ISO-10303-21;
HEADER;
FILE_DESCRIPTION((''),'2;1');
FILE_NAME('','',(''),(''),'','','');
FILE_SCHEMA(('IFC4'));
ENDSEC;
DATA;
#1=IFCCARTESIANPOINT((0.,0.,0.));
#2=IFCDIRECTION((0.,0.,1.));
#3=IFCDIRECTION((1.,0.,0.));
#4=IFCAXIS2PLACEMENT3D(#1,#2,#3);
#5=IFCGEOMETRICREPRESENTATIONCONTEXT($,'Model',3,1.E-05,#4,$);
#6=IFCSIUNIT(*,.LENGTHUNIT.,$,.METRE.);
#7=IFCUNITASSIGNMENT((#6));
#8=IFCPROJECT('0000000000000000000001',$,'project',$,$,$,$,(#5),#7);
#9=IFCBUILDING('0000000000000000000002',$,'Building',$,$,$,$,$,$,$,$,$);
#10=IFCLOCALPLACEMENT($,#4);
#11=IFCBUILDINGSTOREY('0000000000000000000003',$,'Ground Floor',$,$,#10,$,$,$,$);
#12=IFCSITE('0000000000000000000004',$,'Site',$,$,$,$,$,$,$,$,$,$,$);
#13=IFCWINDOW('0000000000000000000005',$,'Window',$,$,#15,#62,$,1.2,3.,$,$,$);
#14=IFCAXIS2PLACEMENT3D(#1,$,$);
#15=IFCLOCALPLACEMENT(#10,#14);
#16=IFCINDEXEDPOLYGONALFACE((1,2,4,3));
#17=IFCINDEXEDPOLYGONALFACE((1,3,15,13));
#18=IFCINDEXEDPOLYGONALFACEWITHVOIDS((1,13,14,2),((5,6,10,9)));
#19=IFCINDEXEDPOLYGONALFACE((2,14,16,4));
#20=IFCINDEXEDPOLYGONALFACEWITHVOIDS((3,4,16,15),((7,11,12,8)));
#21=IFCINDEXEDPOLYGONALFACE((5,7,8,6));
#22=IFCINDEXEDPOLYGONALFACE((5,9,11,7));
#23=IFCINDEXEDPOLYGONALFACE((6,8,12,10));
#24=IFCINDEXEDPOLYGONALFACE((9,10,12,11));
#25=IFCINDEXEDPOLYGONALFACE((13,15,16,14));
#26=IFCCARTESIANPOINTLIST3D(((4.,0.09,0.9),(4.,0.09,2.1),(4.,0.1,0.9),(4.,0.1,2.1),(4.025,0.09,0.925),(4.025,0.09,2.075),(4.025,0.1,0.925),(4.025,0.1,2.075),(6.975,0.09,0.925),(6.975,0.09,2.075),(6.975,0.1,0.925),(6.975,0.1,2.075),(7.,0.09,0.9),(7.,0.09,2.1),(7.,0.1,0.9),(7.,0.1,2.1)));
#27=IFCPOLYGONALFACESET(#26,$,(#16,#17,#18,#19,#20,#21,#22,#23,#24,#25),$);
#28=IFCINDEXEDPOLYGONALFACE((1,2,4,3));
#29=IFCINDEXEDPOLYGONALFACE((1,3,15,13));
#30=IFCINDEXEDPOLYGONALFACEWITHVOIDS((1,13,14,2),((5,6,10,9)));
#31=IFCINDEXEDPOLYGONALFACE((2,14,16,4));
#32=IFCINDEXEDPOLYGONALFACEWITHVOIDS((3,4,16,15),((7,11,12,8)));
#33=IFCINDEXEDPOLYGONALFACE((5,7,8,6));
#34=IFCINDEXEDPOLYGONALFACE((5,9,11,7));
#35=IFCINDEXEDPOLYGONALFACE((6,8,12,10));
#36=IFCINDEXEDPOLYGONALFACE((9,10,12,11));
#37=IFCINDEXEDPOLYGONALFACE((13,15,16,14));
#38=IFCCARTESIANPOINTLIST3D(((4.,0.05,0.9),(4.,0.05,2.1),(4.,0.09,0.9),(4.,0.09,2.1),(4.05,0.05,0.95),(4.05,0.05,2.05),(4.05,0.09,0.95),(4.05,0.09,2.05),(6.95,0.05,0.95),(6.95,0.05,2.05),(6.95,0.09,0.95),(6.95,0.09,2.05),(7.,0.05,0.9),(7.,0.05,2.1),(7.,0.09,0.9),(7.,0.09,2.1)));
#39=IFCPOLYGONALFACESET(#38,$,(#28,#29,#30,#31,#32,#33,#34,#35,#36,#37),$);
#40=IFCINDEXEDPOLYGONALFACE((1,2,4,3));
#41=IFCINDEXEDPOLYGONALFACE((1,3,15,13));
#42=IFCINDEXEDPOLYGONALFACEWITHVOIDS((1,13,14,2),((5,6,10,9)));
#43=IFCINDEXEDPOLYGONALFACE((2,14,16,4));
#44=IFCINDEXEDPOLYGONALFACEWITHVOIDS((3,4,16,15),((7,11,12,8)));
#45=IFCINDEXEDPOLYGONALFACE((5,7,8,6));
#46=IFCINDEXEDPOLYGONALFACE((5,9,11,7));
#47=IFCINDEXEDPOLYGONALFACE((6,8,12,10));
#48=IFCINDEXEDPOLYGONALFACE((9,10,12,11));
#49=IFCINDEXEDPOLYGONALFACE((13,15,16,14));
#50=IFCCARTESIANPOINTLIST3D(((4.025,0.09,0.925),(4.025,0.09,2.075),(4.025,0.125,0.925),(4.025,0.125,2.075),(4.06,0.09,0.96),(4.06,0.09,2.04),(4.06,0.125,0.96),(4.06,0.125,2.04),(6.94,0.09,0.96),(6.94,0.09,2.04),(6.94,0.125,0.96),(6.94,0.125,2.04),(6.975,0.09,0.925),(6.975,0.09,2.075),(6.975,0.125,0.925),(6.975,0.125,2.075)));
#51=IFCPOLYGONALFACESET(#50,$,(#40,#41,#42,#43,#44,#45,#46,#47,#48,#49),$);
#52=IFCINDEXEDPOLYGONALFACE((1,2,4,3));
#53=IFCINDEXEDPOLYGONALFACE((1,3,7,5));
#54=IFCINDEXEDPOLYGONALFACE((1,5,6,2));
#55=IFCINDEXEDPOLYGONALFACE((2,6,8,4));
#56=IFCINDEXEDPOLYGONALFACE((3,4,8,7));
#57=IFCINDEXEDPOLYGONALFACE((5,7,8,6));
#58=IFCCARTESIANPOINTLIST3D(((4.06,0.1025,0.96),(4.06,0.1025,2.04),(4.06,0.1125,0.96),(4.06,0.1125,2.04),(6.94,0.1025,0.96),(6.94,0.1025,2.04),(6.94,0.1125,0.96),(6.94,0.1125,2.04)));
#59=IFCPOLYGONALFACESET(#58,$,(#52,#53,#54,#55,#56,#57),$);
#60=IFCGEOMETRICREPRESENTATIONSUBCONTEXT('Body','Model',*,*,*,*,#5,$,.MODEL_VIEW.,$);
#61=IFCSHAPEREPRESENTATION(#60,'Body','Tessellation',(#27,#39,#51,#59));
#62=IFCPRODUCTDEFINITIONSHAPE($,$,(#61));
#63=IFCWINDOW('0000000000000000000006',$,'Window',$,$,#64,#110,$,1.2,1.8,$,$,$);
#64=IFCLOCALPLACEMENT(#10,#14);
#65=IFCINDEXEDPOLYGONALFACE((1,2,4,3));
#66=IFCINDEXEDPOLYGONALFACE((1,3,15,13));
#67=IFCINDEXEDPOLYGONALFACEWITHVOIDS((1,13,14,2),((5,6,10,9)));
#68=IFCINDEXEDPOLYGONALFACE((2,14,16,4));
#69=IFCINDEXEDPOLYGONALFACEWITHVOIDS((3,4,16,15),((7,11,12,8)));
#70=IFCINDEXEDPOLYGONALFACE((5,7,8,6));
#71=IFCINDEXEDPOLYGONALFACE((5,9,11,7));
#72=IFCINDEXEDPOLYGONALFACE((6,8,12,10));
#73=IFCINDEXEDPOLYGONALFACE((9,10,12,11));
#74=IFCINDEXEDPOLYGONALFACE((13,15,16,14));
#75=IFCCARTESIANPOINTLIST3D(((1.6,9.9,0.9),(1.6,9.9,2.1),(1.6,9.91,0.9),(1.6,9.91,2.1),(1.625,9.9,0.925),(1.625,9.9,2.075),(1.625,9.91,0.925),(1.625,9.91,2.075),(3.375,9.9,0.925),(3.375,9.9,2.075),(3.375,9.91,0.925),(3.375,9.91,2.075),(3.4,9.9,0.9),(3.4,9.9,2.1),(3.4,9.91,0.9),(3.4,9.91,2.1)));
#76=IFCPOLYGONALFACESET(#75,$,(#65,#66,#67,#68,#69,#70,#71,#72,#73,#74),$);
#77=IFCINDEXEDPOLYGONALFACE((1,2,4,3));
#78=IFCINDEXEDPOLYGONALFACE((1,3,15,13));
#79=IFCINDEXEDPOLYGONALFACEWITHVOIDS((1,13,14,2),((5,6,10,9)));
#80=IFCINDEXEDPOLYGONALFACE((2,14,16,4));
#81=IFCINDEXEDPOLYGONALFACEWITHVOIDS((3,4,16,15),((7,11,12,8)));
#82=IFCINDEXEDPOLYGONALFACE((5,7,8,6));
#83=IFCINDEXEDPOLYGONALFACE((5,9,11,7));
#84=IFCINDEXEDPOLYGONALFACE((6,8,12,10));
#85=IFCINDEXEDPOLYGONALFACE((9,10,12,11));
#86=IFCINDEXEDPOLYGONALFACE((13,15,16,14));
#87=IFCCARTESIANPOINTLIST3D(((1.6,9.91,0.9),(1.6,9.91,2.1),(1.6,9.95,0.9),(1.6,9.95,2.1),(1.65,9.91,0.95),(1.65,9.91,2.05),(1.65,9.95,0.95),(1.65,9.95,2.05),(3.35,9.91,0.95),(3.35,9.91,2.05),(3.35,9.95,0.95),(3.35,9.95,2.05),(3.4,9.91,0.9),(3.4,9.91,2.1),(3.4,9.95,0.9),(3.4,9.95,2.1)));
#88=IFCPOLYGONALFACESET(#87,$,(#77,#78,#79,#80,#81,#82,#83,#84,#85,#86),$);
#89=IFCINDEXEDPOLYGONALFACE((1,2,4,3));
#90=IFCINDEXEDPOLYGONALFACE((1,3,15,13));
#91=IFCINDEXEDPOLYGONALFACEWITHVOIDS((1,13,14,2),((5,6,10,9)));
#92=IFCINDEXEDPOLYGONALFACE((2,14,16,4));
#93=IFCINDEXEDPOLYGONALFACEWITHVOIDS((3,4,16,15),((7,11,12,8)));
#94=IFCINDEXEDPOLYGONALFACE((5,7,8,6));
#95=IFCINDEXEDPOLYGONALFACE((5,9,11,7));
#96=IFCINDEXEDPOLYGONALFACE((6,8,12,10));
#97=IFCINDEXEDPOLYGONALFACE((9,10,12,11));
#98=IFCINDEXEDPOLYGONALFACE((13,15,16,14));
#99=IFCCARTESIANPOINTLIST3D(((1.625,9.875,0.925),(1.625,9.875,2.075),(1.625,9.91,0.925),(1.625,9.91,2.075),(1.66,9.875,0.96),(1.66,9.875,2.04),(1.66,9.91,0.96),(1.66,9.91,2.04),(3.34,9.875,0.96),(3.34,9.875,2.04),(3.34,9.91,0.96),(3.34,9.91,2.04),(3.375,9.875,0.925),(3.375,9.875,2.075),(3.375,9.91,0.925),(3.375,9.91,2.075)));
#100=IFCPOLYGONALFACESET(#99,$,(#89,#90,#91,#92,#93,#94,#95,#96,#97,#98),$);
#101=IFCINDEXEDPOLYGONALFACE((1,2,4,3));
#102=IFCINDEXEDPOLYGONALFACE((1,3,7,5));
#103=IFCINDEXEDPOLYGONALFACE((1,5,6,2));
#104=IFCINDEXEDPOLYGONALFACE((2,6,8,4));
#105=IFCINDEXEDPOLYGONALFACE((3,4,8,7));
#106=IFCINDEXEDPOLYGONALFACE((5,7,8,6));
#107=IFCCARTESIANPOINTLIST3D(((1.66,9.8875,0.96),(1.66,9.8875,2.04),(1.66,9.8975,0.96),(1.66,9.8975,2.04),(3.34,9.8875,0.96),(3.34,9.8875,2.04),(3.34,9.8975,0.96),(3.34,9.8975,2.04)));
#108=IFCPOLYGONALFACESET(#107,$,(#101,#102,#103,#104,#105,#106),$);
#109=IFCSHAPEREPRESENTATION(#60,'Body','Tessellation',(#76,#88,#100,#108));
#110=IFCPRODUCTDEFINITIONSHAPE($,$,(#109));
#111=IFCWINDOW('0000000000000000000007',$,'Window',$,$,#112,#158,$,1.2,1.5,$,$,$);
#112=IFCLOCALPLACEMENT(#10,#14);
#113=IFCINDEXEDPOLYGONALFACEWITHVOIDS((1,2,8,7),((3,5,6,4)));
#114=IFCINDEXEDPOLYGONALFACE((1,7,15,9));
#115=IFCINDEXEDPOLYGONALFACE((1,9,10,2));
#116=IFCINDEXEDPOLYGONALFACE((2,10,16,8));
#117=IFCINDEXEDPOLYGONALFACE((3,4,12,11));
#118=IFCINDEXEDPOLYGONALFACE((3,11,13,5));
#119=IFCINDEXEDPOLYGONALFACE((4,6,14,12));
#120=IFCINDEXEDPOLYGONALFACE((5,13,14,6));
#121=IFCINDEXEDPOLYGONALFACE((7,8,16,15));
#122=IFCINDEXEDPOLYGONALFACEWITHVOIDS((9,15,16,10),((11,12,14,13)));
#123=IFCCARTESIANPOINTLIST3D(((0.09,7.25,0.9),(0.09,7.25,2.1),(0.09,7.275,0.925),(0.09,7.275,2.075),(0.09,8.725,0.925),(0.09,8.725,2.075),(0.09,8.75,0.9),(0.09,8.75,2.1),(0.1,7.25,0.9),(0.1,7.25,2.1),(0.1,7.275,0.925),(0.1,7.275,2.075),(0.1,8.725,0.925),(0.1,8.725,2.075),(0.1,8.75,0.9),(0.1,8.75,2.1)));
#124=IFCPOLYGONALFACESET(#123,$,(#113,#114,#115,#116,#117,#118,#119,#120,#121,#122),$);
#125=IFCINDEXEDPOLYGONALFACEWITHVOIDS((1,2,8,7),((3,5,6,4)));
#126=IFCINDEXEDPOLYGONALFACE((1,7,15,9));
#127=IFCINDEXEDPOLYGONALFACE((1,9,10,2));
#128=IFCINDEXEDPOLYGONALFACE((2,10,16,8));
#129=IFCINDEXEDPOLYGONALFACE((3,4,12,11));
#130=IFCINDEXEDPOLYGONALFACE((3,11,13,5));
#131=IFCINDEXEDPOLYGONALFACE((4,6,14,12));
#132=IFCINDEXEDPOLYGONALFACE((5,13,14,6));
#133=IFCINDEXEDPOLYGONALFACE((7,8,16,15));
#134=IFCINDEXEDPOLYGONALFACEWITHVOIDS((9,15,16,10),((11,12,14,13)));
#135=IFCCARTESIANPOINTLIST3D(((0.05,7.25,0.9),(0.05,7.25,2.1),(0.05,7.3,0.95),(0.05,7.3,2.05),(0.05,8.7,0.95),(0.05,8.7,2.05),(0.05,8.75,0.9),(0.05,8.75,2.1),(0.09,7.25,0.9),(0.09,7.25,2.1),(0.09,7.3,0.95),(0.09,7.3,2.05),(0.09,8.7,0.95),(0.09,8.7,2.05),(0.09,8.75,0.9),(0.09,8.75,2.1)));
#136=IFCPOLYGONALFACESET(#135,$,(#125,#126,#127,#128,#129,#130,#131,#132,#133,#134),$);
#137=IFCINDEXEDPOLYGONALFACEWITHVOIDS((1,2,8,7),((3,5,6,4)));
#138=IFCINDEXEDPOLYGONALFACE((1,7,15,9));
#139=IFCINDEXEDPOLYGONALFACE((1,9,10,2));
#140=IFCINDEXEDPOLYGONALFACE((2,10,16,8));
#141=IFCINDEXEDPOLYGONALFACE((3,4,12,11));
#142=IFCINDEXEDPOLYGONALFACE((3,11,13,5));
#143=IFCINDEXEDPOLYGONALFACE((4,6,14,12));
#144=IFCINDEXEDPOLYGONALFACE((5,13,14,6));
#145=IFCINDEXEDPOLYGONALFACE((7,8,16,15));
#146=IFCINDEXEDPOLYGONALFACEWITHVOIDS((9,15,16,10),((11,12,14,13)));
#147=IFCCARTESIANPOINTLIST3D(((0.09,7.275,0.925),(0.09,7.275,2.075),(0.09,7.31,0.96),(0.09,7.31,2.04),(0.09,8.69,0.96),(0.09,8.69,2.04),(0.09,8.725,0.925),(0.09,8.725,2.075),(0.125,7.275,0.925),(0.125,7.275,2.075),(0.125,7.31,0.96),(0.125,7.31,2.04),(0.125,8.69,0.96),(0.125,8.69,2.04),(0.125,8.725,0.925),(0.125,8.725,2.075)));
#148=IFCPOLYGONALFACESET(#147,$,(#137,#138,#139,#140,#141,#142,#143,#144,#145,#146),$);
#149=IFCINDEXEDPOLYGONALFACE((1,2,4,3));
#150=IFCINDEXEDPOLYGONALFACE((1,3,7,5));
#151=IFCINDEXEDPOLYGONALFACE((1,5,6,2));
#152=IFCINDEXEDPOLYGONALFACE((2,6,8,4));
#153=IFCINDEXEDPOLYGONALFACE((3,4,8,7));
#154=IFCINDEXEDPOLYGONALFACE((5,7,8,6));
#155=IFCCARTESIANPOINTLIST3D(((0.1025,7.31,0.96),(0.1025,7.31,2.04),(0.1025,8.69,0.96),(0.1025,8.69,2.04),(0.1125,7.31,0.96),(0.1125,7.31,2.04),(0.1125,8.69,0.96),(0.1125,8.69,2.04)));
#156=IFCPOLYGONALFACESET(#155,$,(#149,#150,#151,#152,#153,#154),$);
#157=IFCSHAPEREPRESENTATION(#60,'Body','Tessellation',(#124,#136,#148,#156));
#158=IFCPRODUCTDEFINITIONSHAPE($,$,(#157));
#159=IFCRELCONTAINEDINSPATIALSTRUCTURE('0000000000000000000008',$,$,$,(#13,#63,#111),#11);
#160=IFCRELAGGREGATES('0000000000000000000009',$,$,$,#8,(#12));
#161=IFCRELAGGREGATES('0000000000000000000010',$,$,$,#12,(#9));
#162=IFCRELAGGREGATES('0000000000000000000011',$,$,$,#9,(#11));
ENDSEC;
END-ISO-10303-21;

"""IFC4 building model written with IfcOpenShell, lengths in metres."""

from ifc_helpers import new_model, si_unit, frame, origin_with_axes, place, context, subcontext, project, spatial, line, indexed_curve, outline, extrude, element, save


model = new_model("IFC4")

# Units and contexts
model_context = context("Model", 3, precision=1e-05, world=origin_with_axes())
body_context = subcontext(model_context, "Body", "Model", "MODEL_VIEW")
ifc_project = project(units=[si_unit("LENGTHUNIT", "METRE")], contexts=[model_context])

# Site, building, storey
site = spatial("IfcSite", under=ifc_project, Name="Site")
building = spatial("IfcBuilding", under=site, Name="Building")
storey_placement = place(None, origin_with_axes())
storey = spatial("IfcBuildingStorey", under=building, at=storey_placement, Name="Ground Floor")

# Windows
window_1_placement = place(storey_placement, frame((4.0, 0.0, 0.9), z_axis=(0.0, 0.0, 1.0), x_axis=(1.0, 0.0, 0.0)))
element("IfcWindow", 1, at=window_1_placement, inside=storey, Name="Window", OverallHeight=1.2, OverallWidth=3.0, context=body_context, shape_type="SweptSolid", body=[
    extrude(outline(indexed_curve([(0.0, 0.0), (3.0, 0.0), (3.0, 1.2), (0.0, 1.2)], segments=[line(1, 2, 3, 4, 1)]), holes=[indexed_curve([(0.025, 0.025), (2.975, 0.025), (2.975, 1.175), (0.025, 1.175)], segments=[line(1, 2, 3, 4, 1)])]), frame((0.0, 0.09, 0.0), z_axis=(0.0, -1.0, 0.0), x_axis=(1.0, 0.0, 0.0)), (0.0, 0.0, -1.0), 0.01),
    extrude(outline(indexed_curve([(0.0, 0.0), (3.0, 0.0), (3.0, 1.2), (0.0, 1.2)], segments=[line(1, 2, 3, 4, 1)]), holes=[indexed_curve([(0.05, 0.05), (2.95, 0.05), (2.95, 1.15), (0.05, 1.15)], segments=[line(1, 2, 3, 4, 1)])]), frame((0.0, 0.05, 0.0), z_axis=(0.0, -1.0, 0.0), x_axis=(1.0, 0.0, 0.0)), (0.0, 0.0, -1.0), 0.04),
    extrude(outline(indexed_curve([(0.0, 0.0), (2.95, 0.0), (2.95, 1.15), (0.0, 1.15)], segments=[line(1, 2, 3, 4, 1)]), holes=[indexed_curve([(0.035, 0.035), (2.915, 0.035), (2.915, 1.115), (0.035, 1.115)], segments=[line(1, 2, 3, 4, 1)])]), frame((0.025, 0.09, 0.025), z_axis=(0.0, -1.0, 0.0), x_axis=(1.0, 0.0, 0.0)), (0.0, 0.0, -1.0), 0.035),
    extrude(outline(indexed_curve([(0.035, 0.035), (2.915, 0.035), (2.915, 1.115), (0.035, 1.115)], segments=[line(1, 2, 3, 4, 1)])), frame((0.025, 0.1025, 0.025), z_axis=(0.0, -1.0, 0.0), x_axis=(1.0, 0.0, 0.0)), (0.0, 0.0, -1.0), 0.01),
])
window_2_placement = place(storey_placement, frame((3.4, 10.0, 0.9), z_axis=(0.0, 0.0, 1.0), x_axis=(-1.0, 0.0, 0.0)))
element("IfcWindow", 2, at=window_2_placement, inside=storey, Name="Window", OverallHeight=1.2, OverallWidth=1.8, context=body_context, shape_type="SweptSolid", body=[
    extrude(outline(indexed_curve([(0.0, 0.0), (1.8, 0.0), (1.8, 1.2), (0.0, 1.2)], segments=[line(1, 2, 3, 4, 1)]), holes=[indexed_curve([(0.025, 0.025), (1.775, 0.025), (1.775, 1.175), (0.025, 1.175)], segments=[line(1, 2, 3, 4, 1)])]), frame((0.0, 0.09, 0.0), z_axis=(0.0, -1.0, 0.0), x_axis=(1.0, 0.0, 0.0)), (0.0, 0.0, -1.0), 0.01),
    extrude(outline(indexed_curve([(0.0, 0.0), (1.8, 0.0), (1.8, 1.2), (0.0, 1.2)], segments=[line(1, 2, 3, 4, 1)]), holes=[indexed_curve([(0.05, 0.05), (1.75, 0.05), (1.75, 1.15), (0.05, 1.15)], segments=[line(1, 2, 3, 4, 1)])]), frame((0.0, 0.05, 0.0), z_axis=(0.0, -1.0, 0.0), x_axis=(1.0, 0.0, 0.0)), (0.0, 0.0, -1.0), 0.04),
    extrude(outline(indexed_curve([(0.0, 0.0), (1.75, 0.0), (1.75, 1.15), (0.0, 1.15)], segments=[line(1, 2, 3, 4, 1)]), holes=[indexed_curve([(0.035, 0.035), (1.715, 0.035), (1.715, 1.115), (0.035, 1.115)], segments=[line(1, 2, 3, 4, 1)])]), frame((0.025, 0.09, 0.025), z_axis=(0.0, -1.0, 0.0), x_axis=(1.0, 0.0, 0.0)), (0.0, 0.0, -1.0), 0.035),
    extrude(outline(indexed_curve([(0.035, 0.035), (1.715, 0.035), (1.715, 1.115), (0.035, 1.115)], segments=[line(1, 2, 3, 4, 1)])), frame((0.025, 0.1025, 0.025), z_axis=(0.0, -1.0, 0.0), x_axis=(1.0, 0.0, 0.0)), (0.0, 0.0, -1.0), 0.01),
])
window_3_placement = place(storey_placement, frame((0.0, 8.75, 0.9), z_axis=(0.0, 0.0, 1.0), x_axis=(0.0, -1.0, 0.0)))
element("IfcWindow", 3, at=window_3_placement, inside=storey, Name="Window", OverallHeight=1.2, OverallWidth=1.5, context=body_context, shape_type="SweptSolid", body=[
    extrude(outline(indexed_curve([(0.0, 0.0), (1.5, 0.0), (1.5, 1.2), (0.0, 1.2)], segments=[line(1, 2, 3, 4, 1)]), holes=[indexed_curve([(0.025, 0.025), (1.475, 0.025), (1.475, 1.175), (0.025, 1.175)], segments=[line(1, 2, 3, 4, 1)])]), frame((0.0, 0.09, 0.0), z_axis=(0.0, -1.0, 0.0), x_axis=(1.0, 0.0, 0.0)), (0.0, 0.0, -1.0), 0.01),
    extrude(outline(indexed_curve([(0.0, 0.0), (1.5, 0.0), (1.5, 1.2), (0.0, 1.2)], segments=[line(1, 2, 3, 4, 1)]), holes=[indexed_curve([(0.05, 0.05), (1.45, 0.05), (1.45, 1.15), (0.05, 1.15)], segments=[line(1, 2, 3, 4, 1)])]), frame((0.0, 0.05, 0.0), z_axis=(0.0, -1.0, 0.0), x_axis=(1.0, 0.0, 0.0)), (0.0, 0.0, -1.0), 0.04),
    extrude(outline(indexed_curve([(0.0, 0.0), (1.45, 0.0), (1.45, 1.15), (0.0, 1.15)], segments=[line(1, 2, 3, 4, 1)]), holes=[indexed_curve([(0.035, 0.035), (1.415, 0.035), (1.415, 1.115), (0.035, 1.115)], segments=[line(1, 2, 3, 4, 1)])]), frame((0.025, 0.09, 0.025), z_axis=(0.0, -1.0, 0.0), x_axis=(1.0, 0.0, 0.0)), (0.0, 0.0, -1.0), 0.035),
    extrude(outline(indexed_curve([(0.035, 0.035), (1.415, 0.035), (1.415, 1.115), (0.035, 1.115)], segments=[line(1, 2, 3, 4, 1)])), frame((0.025, 0.1025, 0.025), z_axis=(0.0, -1.0, 0.0), x_axis=(1.0, 0.0, 0.0)), (0.0, 0.0, -1.0), 0.01),
])

save(model, "model.ifc")
